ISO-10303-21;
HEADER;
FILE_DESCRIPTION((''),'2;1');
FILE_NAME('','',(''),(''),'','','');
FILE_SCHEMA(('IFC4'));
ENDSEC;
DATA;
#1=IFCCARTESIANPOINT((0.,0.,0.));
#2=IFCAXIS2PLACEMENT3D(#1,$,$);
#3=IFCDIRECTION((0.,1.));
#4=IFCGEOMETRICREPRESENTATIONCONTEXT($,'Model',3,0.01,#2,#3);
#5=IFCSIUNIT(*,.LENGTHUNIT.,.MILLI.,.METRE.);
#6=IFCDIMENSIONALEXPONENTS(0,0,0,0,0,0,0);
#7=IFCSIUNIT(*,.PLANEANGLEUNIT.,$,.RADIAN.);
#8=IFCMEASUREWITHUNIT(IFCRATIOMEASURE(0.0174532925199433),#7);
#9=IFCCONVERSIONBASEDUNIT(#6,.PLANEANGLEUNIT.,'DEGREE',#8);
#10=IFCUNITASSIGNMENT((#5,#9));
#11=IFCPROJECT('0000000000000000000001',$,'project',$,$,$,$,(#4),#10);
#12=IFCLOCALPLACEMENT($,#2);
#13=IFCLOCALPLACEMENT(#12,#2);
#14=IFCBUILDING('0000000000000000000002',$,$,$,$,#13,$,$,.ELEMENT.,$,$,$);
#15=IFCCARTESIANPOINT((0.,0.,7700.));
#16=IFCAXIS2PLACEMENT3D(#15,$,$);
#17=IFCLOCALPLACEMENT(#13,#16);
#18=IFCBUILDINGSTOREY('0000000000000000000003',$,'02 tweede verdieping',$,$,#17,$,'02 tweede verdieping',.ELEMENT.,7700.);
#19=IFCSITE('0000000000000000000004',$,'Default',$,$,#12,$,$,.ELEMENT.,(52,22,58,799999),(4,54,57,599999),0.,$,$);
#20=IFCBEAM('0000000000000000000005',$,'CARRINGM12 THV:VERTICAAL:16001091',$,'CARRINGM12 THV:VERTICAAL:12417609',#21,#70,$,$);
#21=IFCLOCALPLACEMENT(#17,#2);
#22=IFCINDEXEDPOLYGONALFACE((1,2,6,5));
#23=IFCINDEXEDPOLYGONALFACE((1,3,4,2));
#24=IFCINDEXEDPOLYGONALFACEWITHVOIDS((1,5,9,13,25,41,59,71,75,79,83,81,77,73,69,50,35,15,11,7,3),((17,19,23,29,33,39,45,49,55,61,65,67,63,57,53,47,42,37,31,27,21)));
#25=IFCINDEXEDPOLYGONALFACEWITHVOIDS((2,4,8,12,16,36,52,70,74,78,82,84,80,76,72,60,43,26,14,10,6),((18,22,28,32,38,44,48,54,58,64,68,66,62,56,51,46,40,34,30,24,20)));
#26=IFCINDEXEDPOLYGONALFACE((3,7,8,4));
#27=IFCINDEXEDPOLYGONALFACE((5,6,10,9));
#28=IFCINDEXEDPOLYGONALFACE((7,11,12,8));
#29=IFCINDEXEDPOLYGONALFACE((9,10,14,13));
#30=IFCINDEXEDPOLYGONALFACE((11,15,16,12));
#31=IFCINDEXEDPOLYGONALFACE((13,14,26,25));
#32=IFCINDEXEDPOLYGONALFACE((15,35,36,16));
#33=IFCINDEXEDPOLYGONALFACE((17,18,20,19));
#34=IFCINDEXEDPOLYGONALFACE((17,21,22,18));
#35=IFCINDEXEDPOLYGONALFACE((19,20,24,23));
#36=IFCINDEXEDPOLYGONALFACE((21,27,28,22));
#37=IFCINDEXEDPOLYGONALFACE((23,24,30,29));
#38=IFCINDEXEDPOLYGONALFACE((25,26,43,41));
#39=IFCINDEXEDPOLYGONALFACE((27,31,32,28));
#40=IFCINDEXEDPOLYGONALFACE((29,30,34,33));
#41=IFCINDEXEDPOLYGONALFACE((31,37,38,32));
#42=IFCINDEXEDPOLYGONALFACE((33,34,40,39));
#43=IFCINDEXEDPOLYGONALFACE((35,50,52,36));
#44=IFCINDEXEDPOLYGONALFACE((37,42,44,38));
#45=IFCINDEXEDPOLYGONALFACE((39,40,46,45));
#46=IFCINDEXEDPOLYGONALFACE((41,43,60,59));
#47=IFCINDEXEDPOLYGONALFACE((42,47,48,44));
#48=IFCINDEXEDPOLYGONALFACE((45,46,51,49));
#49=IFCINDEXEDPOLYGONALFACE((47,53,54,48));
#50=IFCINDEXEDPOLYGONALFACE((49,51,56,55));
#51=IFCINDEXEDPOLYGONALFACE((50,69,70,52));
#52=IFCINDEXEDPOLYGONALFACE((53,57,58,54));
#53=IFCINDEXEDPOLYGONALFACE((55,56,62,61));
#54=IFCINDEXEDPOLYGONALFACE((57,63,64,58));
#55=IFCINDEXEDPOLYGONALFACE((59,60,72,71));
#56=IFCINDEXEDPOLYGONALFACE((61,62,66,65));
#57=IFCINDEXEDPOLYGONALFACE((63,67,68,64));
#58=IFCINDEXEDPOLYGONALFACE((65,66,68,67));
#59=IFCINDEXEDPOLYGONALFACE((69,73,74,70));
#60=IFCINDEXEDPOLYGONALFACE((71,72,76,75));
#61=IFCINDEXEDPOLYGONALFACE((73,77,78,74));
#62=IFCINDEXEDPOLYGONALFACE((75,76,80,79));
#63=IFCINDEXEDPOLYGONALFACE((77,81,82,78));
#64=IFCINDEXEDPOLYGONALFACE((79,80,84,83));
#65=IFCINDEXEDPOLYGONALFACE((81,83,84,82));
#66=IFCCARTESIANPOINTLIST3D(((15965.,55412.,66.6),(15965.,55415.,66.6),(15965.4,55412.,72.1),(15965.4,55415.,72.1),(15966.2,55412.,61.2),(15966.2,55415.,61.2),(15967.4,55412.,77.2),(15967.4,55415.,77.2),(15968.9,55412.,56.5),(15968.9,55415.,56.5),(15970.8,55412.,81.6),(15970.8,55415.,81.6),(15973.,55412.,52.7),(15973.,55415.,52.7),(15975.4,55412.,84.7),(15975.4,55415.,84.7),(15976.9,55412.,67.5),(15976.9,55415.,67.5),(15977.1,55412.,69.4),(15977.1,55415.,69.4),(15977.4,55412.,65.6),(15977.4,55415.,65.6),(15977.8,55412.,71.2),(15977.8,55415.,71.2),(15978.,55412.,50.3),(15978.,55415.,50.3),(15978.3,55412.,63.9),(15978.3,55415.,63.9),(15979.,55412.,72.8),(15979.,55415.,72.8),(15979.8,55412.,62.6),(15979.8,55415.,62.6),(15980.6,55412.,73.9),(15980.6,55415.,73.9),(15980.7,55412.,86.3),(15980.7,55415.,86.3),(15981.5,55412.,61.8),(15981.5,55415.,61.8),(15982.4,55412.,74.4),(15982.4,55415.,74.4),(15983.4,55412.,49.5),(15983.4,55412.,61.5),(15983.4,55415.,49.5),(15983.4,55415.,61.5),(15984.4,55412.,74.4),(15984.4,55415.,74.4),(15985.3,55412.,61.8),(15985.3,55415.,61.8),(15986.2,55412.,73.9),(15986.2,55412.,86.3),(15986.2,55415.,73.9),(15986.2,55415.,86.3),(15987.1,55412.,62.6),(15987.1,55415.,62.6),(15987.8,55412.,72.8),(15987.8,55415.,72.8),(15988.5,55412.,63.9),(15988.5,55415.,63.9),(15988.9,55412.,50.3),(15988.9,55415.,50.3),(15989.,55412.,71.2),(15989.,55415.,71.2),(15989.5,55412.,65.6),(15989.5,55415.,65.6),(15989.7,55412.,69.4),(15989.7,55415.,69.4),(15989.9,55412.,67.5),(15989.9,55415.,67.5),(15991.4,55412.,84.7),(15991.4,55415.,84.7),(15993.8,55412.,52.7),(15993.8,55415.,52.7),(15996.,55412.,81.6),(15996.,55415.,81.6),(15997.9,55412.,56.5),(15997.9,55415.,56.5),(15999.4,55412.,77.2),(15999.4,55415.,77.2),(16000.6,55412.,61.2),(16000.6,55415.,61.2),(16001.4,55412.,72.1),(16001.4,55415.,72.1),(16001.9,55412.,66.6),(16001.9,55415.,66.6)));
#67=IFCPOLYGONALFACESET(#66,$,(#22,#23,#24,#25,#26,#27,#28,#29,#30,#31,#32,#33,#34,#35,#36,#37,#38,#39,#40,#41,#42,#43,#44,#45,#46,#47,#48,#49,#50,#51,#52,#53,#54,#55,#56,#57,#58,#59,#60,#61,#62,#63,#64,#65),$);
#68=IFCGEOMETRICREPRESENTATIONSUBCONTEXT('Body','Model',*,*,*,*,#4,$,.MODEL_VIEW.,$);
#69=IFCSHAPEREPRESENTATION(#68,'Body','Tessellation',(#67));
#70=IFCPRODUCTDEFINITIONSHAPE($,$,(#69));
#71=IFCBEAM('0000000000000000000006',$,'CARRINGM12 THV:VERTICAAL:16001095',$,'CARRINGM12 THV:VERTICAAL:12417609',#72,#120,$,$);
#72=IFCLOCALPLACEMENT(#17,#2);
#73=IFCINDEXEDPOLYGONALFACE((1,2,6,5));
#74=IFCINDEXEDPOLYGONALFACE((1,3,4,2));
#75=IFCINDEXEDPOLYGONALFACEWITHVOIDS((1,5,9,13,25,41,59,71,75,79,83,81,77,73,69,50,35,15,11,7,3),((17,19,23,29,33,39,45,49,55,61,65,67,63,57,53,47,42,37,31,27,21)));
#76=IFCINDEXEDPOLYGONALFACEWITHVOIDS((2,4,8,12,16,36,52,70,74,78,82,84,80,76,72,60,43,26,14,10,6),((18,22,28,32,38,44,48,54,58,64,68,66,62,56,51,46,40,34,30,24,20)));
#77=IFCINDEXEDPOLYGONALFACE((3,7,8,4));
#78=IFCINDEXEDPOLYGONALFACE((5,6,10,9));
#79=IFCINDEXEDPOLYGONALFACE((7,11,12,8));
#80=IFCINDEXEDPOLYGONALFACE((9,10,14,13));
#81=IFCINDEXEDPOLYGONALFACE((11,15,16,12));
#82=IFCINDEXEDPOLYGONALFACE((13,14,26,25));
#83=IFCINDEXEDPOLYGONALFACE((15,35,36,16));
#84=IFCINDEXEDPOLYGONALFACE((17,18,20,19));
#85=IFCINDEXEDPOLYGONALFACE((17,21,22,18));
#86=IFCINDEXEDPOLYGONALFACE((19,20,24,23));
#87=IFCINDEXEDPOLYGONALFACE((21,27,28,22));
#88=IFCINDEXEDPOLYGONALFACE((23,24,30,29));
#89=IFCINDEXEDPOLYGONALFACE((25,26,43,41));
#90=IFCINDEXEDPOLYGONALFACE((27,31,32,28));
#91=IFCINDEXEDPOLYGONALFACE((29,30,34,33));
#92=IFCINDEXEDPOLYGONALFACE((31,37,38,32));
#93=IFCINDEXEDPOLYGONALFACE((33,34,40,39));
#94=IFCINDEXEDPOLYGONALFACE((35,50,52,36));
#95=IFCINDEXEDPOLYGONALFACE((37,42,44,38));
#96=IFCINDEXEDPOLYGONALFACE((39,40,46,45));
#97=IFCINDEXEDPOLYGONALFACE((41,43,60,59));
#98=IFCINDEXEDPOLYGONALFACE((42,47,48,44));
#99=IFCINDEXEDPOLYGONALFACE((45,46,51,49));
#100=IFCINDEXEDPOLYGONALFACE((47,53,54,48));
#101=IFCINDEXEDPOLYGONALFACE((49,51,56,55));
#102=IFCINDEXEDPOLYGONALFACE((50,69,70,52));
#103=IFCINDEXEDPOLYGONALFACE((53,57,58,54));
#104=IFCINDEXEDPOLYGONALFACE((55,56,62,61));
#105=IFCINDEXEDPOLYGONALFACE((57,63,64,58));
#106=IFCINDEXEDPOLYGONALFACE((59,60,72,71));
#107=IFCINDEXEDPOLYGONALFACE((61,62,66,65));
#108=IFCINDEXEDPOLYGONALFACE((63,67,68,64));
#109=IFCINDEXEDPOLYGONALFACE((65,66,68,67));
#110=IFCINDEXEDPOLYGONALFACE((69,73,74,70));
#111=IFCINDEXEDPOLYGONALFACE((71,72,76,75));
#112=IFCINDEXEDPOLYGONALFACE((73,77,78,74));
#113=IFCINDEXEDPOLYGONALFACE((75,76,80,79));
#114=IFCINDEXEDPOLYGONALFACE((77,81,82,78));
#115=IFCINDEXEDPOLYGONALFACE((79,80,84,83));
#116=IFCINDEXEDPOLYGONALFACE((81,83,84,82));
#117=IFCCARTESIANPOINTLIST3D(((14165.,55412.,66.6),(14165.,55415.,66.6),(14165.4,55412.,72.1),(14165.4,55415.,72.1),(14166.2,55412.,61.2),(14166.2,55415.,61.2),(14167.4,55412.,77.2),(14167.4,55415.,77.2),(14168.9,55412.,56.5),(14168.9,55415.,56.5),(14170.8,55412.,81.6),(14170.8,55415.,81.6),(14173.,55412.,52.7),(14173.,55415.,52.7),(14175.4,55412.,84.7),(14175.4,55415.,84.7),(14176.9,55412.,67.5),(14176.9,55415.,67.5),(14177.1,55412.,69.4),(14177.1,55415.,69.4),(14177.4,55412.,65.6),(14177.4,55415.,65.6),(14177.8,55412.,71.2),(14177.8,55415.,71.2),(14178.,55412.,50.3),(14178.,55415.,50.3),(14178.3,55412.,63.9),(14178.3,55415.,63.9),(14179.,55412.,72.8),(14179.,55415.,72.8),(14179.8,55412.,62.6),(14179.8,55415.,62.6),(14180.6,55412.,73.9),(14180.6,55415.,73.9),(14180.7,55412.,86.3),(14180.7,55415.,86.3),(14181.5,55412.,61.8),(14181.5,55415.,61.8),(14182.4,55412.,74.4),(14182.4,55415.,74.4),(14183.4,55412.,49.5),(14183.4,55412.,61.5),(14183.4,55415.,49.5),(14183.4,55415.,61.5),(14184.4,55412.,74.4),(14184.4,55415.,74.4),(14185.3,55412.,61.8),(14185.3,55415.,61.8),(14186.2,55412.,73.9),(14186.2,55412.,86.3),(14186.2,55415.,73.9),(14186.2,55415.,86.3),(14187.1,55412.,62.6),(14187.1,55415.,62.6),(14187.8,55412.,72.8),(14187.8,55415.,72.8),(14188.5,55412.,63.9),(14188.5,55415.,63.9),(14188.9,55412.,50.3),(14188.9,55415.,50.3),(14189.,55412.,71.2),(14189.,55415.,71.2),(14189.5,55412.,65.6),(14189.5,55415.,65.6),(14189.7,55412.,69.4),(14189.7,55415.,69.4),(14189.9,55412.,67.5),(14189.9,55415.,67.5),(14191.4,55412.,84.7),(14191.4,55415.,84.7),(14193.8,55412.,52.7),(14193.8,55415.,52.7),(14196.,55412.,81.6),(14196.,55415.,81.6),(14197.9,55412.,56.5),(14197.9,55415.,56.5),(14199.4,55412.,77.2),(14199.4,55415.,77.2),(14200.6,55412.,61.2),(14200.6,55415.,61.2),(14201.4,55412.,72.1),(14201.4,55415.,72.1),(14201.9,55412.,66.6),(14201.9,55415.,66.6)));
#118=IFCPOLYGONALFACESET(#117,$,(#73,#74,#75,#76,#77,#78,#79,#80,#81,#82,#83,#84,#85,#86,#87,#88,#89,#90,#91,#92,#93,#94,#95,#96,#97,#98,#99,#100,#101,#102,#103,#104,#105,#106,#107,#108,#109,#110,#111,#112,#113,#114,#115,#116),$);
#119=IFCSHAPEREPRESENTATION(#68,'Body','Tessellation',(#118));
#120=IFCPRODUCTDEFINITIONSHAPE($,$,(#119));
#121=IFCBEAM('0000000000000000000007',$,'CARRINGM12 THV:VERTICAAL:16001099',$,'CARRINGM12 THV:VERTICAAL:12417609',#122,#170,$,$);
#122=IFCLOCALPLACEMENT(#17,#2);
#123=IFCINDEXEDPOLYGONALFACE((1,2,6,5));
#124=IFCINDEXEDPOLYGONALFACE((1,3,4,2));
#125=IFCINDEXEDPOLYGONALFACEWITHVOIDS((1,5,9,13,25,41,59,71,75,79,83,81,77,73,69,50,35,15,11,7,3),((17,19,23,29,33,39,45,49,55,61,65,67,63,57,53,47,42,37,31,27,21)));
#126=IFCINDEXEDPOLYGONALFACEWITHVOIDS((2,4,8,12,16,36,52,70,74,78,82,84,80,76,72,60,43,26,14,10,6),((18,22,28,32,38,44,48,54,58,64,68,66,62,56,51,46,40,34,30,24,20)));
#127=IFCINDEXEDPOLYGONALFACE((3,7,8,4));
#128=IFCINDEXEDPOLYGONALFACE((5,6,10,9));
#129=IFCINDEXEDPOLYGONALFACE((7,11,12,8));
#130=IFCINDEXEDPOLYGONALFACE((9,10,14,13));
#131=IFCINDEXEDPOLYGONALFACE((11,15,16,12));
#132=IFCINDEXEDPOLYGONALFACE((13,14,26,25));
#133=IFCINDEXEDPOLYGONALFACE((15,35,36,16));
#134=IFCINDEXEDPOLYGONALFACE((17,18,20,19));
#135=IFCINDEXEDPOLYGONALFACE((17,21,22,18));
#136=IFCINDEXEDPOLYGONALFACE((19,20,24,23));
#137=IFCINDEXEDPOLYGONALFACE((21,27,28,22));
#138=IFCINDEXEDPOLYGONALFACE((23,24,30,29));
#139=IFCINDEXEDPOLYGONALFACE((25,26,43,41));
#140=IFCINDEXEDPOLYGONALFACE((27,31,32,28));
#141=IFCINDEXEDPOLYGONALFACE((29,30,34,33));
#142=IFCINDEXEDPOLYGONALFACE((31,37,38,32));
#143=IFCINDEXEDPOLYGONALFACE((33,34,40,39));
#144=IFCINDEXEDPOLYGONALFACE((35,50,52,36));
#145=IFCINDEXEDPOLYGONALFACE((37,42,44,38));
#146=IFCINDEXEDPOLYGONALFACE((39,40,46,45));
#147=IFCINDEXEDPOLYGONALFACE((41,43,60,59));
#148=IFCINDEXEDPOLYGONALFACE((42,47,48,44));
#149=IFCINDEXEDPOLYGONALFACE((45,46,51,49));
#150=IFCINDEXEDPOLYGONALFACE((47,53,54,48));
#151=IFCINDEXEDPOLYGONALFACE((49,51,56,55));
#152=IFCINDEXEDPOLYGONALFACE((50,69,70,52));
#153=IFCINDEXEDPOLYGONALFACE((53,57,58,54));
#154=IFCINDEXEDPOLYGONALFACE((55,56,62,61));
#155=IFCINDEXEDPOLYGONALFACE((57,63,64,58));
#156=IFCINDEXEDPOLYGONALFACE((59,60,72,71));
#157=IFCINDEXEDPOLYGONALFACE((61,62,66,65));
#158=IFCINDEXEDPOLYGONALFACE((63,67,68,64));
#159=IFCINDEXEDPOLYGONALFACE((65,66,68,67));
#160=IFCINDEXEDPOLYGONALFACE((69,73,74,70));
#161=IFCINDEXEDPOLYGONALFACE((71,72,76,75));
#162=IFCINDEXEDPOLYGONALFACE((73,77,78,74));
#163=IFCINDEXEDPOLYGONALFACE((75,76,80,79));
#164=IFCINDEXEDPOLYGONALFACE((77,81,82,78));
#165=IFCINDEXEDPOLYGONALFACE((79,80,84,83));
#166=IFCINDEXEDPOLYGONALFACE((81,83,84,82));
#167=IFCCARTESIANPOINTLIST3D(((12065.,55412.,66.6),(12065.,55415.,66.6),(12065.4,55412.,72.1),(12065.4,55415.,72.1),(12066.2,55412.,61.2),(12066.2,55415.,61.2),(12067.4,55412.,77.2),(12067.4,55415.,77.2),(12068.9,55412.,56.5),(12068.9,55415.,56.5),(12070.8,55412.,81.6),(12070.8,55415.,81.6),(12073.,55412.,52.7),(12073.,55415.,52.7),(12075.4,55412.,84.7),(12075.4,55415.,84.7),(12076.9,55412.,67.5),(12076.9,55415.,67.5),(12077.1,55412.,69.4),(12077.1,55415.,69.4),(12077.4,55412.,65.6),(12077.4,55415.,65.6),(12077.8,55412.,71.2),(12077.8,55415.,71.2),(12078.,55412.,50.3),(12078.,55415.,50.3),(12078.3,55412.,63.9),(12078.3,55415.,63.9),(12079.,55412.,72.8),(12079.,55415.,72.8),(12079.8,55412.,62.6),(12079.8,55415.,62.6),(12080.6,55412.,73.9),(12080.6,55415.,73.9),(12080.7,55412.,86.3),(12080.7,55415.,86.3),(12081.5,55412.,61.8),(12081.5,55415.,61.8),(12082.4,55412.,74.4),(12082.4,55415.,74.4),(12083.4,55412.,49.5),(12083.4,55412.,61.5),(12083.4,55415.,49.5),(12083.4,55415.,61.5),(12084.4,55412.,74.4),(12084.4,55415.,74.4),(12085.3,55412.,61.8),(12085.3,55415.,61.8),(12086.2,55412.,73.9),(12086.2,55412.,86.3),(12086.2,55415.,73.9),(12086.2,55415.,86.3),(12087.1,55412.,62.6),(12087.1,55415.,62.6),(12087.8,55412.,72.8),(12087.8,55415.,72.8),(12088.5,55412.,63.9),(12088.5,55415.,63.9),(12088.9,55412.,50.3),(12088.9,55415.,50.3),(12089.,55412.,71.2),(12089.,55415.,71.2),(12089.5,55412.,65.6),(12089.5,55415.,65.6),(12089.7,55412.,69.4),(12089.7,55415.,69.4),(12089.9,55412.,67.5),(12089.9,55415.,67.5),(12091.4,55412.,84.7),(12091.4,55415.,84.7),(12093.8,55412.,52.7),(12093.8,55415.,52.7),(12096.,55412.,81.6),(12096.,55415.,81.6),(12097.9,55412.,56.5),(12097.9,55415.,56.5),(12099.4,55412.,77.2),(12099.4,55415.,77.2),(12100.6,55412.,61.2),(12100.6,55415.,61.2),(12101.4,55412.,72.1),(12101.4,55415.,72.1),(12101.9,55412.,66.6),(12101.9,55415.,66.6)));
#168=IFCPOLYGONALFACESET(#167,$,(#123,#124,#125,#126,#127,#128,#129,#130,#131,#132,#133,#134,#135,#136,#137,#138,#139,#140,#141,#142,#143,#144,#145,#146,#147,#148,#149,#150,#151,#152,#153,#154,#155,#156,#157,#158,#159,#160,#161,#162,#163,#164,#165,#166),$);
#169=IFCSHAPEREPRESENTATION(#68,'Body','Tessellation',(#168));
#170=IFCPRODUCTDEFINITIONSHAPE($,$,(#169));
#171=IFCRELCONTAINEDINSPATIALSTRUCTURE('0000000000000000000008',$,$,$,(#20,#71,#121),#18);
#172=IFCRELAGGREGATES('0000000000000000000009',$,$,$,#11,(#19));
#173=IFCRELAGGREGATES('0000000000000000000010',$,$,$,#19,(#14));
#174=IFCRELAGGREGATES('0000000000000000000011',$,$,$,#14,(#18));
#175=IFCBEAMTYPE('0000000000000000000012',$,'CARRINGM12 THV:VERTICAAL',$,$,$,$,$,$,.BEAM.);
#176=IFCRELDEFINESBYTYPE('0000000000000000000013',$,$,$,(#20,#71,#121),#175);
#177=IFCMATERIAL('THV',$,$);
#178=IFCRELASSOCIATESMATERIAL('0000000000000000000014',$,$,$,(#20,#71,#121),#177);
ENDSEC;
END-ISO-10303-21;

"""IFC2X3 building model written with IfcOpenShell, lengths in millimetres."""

from ifc_helpers import new_model, entity, si_unit, converted_unit, direction, frame, origin, origin_2d_with_axis, place, context, subcontext, project, spatial, hollow_circle, extrude, material, type_object, element, save


model = new_model("IFC2X3")

# Units and contexts
model_context = context("Model", 3, precision=0.01, world=origin(), true_north=direction((0.0, 1.0)))
body_context = subcontext(model_context, "Body", "Model", "MODEL_VIEW")
ifc_project = project(units=[si_unit("LENGTHUNIT", "METRE", prefix="MILLI"), converted_unit("PLANEANGLEUNIT", "DEGREE", entity("IfcRatioMeasure", 0.0174532925199433), si_unit("PLANEANGLEUNIT", "RADIAN"), dimensions=[0, 0, 0, 0, 0, 0, 0])], contexts=[model_context])

# Site, building, storey
site_placement = place(None, origin())
site = spatial("IfcSite", under=ifc_project, at=site_placement, Name="Default", CompositionType="ELEMENT", RefLatitude=(52, 22, 58, 799999), RefLongitude=(4, 54, 57, 599999), RefElevation=0.0)
building_placement = place(site_placement, origin())
building = spatial("IfcBuilding", under=site, at=building_placement, CompositionType="ELEMENT")
storey_placement = place(building_placement, frame((0.0, 0.0, 7700.0)))
storey = spatial("IfcBuildingStorey", under=building, at=storey_placement, Name="02 tweede verdieping", LongName="02 tweede verdieping", CompositionType="ELEMENT", Elevation=7700.0)

# Beams
ifc_material_1 = material(Name="THV")
beam_type_1 = type_object("IfcBeamType", Name="CARRINGM12 THV:VERTICAAL", PredefinedType="BEAM")
beam_1_placement = place(storey_placement, origin())
element("IfcBeam", 1, at=beam_1_placement, inside=storey, type_object=beam_type_1, material=ifc_material_1, Name="CARRINGM12 THV:VERTICAAL:16001091", ObjectType="CARRINGM12 THV:VERTICAAL:12417609", context=body_context, shape_type="SweptSolid", body=[
    extrude(hollow_circle(Radius=18.5, WallThickness=12.0, at=origin_2d_with_axis()), frame((15983.4, 55412.0, 68.0), z_axis=(0.0, 1.0, 0.0), x_axis=(0.0, 0.0, -1.0)), (0.0, 0.0, 1.0), 3.0),
])
beam_2_placement = place(storey_placement, origin())
element("IfcBeam", 2, at=beam_2_placement, inside=storey, type_object=beam_type_1, material=ifc_material_1, Name="CARRINGM12 THV:VERTICAAL:16001095", ObjectType="CARRINGM12 THV:VERTICAAL:12417609", context=body_context, shape_type="SweptSolid", body=[
    extrude(hollow_circle(Radius=18.5, WallThickness=12.0, at=origin_2d_with_axis()), frame((14183.4, 55412.0, 68.0), z_axis=(0.0, 1.0, 0.0), x_axis=(0.0, 0.0, -1.0)), (0.0, 0.0, 1.0), 3.0),
])
beam_3_placement = place(storey_placement, origin())
element("IfcBeam", 3, at=beam_3_placement, inside=storey, type_object=beam_type_1, material=ifc_material_1, Name="CARRINGM12 THV:VERTICAAL:16001099", ObjectType="CARRINGM12 THV:VERTICAAL:12417609", context=body_context, shape_type="SweptSolid", body=[
    extrude(hollow_circle(Radius=18.5, WallThickness=12.0, at=origin_2d_with_axis()), frame((12083.4, 55412.0, 68.0), z_axis=(0.0, 1.0, 0.0), x_axis=(0.0, 0.0, -1.0)), (0.0, 0.0, 1.0), 3.0),
])

save(model, "model.ifc")
